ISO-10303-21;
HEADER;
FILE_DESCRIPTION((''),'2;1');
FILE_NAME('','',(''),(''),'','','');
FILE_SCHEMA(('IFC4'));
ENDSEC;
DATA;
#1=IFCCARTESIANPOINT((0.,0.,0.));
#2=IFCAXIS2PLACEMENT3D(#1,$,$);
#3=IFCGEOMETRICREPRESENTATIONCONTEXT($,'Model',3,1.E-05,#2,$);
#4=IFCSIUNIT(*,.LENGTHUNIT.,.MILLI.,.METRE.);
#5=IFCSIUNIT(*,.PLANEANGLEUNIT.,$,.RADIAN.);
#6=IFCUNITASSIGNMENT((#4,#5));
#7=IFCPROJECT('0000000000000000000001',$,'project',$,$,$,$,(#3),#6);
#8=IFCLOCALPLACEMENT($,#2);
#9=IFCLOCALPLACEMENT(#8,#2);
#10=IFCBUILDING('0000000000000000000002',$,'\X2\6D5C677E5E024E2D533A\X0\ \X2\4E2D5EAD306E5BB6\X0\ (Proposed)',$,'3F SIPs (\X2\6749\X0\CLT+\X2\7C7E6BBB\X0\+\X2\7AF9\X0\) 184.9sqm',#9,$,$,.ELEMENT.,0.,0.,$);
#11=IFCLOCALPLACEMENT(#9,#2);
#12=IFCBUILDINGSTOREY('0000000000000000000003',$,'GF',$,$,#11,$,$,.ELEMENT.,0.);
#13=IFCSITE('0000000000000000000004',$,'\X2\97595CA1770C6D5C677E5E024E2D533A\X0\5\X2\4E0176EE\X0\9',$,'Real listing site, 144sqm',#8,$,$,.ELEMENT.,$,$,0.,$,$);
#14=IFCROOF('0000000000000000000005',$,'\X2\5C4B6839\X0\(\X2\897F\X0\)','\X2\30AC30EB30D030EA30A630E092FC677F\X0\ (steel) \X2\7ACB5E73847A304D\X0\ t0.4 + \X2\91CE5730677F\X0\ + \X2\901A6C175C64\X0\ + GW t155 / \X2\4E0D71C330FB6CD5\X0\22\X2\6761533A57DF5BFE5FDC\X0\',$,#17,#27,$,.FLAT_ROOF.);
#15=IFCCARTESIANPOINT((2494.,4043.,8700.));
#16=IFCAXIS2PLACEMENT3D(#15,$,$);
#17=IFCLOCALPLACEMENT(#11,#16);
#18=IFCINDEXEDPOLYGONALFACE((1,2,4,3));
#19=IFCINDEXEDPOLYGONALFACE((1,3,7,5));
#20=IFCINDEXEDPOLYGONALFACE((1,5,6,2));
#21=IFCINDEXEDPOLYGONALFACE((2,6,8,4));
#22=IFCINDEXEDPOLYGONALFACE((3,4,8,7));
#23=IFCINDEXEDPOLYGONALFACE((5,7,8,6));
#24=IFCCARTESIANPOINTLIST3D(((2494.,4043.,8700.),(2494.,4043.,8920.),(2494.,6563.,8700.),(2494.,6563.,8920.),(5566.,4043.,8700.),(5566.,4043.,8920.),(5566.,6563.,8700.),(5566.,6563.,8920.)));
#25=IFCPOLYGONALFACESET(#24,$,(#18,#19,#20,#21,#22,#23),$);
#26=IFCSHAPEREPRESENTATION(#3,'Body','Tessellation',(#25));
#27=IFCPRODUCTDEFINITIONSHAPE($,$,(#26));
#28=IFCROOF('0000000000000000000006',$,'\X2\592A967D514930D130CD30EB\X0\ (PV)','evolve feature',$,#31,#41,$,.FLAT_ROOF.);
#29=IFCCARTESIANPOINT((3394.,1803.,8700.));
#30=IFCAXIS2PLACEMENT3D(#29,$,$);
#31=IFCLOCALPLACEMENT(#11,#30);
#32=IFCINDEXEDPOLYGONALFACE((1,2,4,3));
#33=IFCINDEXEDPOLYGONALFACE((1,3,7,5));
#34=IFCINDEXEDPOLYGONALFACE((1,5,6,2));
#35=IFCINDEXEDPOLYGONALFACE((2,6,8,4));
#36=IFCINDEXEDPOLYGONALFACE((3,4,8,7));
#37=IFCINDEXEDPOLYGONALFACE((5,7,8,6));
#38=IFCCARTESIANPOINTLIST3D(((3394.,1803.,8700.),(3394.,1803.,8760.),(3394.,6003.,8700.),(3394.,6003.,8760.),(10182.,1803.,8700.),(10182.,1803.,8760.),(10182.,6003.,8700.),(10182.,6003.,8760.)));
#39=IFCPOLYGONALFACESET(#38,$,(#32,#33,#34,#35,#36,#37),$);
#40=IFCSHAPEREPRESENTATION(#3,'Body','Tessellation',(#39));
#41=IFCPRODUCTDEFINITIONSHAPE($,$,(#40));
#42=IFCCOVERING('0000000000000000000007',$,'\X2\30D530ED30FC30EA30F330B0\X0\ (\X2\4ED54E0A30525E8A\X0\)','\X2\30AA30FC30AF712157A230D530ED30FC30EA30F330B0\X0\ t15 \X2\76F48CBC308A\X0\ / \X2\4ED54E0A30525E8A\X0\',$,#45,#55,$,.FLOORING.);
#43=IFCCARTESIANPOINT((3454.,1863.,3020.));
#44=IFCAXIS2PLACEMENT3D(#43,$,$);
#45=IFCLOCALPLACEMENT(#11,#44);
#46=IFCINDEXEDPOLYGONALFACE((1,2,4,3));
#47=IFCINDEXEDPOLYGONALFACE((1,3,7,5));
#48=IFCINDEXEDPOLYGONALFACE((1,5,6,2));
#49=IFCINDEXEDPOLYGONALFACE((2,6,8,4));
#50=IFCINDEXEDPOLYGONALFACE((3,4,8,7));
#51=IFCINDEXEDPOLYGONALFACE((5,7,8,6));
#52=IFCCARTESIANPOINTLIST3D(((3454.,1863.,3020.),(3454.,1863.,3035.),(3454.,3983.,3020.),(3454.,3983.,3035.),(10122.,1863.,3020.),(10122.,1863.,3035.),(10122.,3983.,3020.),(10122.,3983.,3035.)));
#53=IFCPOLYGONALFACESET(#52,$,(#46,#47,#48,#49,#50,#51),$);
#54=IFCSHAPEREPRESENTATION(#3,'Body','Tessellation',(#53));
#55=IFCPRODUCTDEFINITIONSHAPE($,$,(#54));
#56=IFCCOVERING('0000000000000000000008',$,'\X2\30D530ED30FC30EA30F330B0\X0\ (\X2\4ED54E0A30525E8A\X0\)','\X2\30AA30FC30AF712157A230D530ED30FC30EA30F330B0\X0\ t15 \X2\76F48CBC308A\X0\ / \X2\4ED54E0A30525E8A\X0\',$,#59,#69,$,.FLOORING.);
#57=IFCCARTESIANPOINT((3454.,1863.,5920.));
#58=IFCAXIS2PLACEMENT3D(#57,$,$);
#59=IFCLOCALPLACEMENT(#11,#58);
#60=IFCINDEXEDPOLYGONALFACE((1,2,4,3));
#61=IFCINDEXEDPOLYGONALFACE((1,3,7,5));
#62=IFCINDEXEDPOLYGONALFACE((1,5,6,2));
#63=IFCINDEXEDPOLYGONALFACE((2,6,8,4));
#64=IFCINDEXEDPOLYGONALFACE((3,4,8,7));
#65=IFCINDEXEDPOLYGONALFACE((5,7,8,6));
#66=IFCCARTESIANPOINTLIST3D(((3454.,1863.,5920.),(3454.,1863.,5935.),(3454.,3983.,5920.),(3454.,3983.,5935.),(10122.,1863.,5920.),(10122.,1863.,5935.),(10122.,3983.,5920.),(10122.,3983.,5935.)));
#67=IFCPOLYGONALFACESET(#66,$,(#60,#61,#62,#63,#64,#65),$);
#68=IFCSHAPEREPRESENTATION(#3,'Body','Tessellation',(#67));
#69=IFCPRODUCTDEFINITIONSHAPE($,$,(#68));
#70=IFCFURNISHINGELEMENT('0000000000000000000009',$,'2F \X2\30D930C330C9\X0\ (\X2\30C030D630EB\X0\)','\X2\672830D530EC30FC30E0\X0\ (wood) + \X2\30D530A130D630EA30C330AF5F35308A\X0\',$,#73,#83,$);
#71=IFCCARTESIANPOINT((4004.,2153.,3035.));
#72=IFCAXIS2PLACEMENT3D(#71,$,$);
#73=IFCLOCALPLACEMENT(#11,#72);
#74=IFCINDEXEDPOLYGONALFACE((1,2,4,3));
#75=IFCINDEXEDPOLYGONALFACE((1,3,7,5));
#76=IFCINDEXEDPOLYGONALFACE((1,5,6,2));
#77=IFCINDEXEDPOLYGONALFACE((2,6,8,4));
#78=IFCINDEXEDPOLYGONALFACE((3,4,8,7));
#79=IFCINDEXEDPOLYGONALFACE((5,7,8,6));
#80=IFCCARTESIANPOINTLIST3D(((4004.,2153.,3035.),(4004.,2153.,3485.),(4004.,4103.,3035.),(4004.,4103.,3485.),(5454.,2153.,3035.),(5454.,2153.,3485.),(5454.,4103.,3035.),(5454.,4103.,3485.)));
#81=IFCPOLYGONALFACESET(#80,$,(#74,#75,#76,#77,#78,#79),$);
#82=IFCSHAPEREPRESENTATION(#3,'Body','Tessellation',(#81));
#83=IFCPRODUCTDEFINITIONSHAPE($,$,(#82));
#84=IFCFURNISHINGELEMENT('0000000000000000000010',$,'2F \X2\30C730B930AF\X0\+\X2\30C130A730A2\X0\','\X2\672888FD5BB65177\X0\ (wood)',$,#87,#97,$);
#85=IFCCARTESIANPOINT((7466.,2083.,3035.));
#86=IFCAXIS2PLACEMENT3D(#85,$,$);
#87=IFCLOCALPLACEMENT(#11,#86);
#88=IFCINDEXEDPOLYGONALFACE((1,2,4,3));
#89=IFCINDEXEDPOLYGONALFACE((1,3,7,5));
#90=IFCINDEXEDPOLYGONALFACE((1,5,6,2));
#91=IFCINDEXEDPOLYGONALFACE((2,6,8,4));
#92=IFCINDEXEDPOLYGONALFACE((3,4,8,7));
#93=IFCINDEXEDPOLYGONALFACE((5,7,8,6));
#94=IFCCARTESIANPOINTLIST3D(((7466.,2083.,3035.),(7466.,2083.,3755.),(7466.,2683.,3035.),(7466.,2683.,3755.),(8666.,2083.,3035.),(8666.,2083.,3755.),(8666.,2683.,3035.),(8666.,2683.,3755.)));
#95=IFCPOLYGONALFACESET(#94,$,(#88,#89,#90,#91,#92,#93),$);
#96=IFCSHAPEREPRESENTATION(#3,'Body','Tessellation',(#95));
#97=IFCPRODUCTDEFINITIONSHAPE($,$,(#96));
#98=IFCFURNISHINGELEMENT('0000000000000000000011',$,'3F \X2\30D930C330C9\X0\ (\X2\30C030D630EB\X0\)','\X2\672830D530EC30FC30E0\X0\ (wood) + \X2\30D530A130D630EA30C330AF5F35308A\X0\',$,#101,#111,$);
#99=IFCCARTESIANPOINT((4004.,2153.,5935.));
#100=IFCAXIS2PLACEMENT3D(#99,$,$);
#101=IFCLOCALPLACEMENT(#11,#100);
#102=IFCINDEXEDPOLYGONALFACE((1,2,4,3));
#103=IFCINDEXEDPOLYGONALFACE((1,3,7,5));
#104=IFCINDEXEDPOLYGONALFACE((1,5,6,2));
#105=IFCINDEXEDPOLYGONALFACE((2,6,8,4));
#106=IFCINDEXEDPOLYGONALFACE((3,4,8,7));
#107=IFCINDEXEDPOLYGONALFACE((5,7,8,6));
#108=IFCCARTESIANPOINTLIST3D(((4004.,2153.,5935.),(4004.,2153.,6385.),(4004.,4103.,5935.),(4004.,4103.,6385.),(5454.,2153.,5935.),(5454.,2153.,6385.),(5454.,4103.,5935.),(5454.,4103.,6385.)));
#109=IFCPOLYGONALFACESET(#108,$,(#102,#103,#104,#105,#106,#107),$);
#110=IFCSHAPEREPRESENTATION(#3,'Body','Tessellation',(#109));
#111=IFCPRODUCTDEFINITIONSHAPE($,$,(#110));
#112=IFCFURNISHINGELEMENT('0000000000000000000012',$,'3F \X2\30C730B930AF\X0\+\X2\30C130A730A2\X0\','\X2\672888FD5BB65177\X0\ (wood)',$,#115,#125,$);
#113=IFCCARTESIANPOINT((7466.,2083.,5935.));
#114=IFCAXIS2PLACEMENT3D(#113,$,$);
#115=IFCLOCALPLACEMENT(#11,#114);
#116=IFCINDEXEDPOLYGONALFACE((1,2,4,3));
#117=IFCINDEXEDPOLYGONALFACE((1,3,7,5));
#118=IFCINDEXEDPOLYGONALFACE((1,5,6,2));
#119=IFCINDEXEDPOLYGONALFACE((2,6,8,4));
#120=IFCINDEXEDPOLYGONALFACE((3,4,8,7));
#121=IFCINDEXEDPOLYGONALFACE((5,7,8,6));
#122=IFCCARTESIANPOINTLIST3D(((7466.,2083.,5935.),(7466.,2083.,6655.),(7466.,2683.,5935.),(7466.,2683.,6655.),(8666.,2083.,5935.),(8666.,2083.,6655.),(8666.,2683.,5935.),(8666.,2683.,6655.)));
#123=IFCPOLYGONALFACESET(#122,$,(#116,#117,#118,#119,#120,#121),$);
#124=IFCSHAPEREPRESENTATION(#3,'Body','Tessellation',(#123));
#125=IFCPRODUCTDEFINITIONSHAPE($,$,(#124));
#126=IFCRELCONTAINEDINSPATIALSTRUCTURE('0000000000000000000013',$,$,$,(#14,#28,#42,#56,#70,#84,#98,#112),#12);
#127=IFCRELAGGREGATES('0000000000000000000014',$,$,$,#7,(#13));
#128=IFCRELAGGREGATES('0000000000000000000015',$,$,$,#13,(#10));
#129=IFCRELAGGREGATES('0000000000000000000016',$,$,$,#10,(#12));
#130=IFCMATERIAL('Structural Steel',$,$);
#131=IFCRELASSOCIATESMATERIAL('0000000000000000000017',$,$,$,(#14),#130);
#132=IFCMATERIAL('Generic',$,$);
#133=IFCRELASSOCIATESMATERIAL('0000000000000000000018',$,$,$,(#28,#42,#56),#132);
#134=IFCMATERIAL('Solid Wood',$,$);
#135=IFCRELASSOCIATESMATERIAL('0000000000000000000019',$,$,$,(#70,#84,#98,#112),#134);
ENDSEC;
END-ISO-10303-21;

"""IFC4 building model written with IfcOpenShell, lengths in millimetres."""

from ifc_helpers import new_model, si_unit, frame, frame_2d, origin, place, context, project, spatial, rectangle, extrude, material, element, save


model = new_model("IFC4")

# Units and contexts
model_context = context("Model", 3, precision=1e-05, world=origin())
ifc_project = project(units=[si_unit("LENGTHUNIT", "METRE", prefix="MILLI"), si_unit("PLANEANGLEUNIT", "RADIAN")], contexts=[model_context])

# Site, building, storey
site_placement = place(None, origin())
site = spatial("IfcSite", under=ifc_project, at=site_placement, Name="静岡県浜松市中区5丁目9", ObjectType="Real listing site, 144sqm", CompositionType="ELEMENT", RefElevation=0.0)
building_placement = place(site_placement, origin())
building = spatial("IfcBuilding", under=site, at=building_placement, Name="浜松市中区 中庭の家 (Proposed)", ObjectType="3F SIPs (杉CLT+籾殻+竹) 184.9sqm", CompositionType="ELEMENT", ElevationOfRefHeight=0.0, ElevationOfTerrain=0.0)
storey_placement = place(building_placement, origin())
storey = spatial("IfcBuildingStorey", under=building, at=storey_placement, Name="GF", CompositionType="ELEMENT", Elevation=0.0)

# Shared definitions
ifc_material_1 = material(Name="Solid Wood")

# Roofs
ifc_material_2 = material(Name="Structural Steel")
roof_1_placement = place(storey_placement, frame((2494.0, 4043.0, 8700.0)))
element("IfcRoof", 1, at=roof_1_placement, inside=storey, material=ifc_material_2, Name="屋根(西)", Description="ガルバリウム鋼板 (steel) 立平葺き t0.4 + 野地板 + 通気層 + GW t155 / 不燃・法22条区域対応", PredefinedType="FLAT_ROOF", context=model_context, shape_type="SweptSolid", body=[
    extrude(rectangle(XDim=3072.0, YDim=2520.0, at=frame_2d((1536.0, 1260.0))), frame((2494.0, 4043.0, 8700.0)), (0.0, 0.0, 1.0), 220.0),
])
ifc_material_3 = material(Name="Generic")
roof_2_placement = place(storey_placement, frame((3394.0, 1803.0, 8700.0)))
element("IfcRoof", 2, at=roof_2_placement, inside=storey, material=ifc_material_3, Name="太陽光パネル (PV)", Description="evolve feature", PredefinedType="FLAT_ROOF", context=model_context, shape_type="SweptSolid", body=[
    extrude(rectangle(XDim=6788.0, YDim=4200.0, at=frame_2d((3394.0, 2100.0))), frame((3394.0, 1803.0, 8700.0)), (0.0, 0.0, 1.0), 60.0),
])

# Coverings
covering_1_placement = place(storey_placement, frame((3454.0, 1863.0, 3020.0)))
element("IfcCovering", 3, at=covering_1_placement, inside=storey, material=ifc_material_3, Name="フローリング (仕上げ床)", Description="オーク無垢フローリング t15 直貼り / 仕上げ床", PredefinedType="FLOORING", context=model_context, shape_type="SweptSolid", body=[
    extrude(rectangle(XDim=6668.0, YDim=2120.0, at=frame_2d((3334.0, 1060.0))), frame((3454.0, 1863.0, 3020.0)), (0.0, 0.0, 1.0), 15.0),
])
covering_2_placement = place(storey_placement, frame((3454.0, 1863.0, 5920.0)))
element("IfcCovering", 4, at=covering_2_placement, inside=storey, material=ifc_material_3, Name="フローリング (仕上げ床)", Description="オーク無垢フローリング t15 直貼り / 仕上げ床", PredefinedType="FLOORING", context=model_context, shape_type="SweptSolid", body=[
    extrude(rectangle(XDim=6668.0, YDim=2120.0, at=frame_2d((3334.0, 1060.0))), frame((3454.0, 1863.0, 5920.0)), (0.0, 0.0, 1.0), 15.0),
])

# Furnishing elements
furnishing_1_placement = place(storey_placement, frame((4004.0, 2153.0, 3035.0)))
element("IfcFurnishingElement", 5, at=furnishing_1_placement, inside=storey, material=ifc_material_1, Name="2F ベッド (ダブル)", Description="木フレーム (wood) + ファブリック張り", context=model_context, shape_type="SweptSolid", body=[
    extrude(rectangle(XDim=1450.0, YDim=1950.0, at=frame_2d((725.0, 975.0))), frame((4004.0, 2153.0, 3035.0)), (0.0, 0.0, 1.0), 450.0),
])
furnishing_2_placement = place(storey_placement, frame((7466.0, 2083.0, 3035.0)))
element("IfcFurnishingElement", 6, at=furnishing_2_placement, inside=storey, material=ifc_material_1, Name="2F デスク+チェア", Description="木製家具 (wood)", context=model_context, shape_type="SweptSolid", body=[
    extrude(rectangle(XDim=1200.0, YDim=600.0, at=frame_2d((600.0, 300.0))), frame((7466.0, 2083.0, 3035.0)), (0.0, 0.0, 1.0), 720.0),
])
furnishing_3_placement = place(storey_placement, frame((4004.0, 2153.0, 5935.0)))
element("IfcFurnishingElement", 7, at=furnishing_3_placement, inside=storey, material=ifc_material_1, Name="3F ベッド (ダブル)", Description="木フレーム (wood) + ファブリック張り", context=model_context, shape_type="SweptSolid", body=[
    extrude(rectangle(XDim=1450.0, YDim=1950.0, at=frame_2d((725.0, 975.0))), frame((4004.0, 2153.0, 5935.0)), (0.0, 0.0, 1.0), 450.0),
])
furnishing_4_placement = place(storey_placement, frame((7466.0, 2083.0, 5935.0)))
element("IfcFurnishingElement", 8, at=furnishing_4_placement, inside=storey, material=ifc_material_1, Name="3F デスク+チェア", Description="木製家具 (wood)", context=model_context, shape_type="SweptSolid", body=[
    extrude(rectangle(XDim=1200.0, YDim=600.0, at=frame_2d((600.0, 300.0))), frame((7466.0, 2083.0, 5935.0)), (0.0, 0.0, 1.0), 720.0),
])

save(model, "model.ifc")
